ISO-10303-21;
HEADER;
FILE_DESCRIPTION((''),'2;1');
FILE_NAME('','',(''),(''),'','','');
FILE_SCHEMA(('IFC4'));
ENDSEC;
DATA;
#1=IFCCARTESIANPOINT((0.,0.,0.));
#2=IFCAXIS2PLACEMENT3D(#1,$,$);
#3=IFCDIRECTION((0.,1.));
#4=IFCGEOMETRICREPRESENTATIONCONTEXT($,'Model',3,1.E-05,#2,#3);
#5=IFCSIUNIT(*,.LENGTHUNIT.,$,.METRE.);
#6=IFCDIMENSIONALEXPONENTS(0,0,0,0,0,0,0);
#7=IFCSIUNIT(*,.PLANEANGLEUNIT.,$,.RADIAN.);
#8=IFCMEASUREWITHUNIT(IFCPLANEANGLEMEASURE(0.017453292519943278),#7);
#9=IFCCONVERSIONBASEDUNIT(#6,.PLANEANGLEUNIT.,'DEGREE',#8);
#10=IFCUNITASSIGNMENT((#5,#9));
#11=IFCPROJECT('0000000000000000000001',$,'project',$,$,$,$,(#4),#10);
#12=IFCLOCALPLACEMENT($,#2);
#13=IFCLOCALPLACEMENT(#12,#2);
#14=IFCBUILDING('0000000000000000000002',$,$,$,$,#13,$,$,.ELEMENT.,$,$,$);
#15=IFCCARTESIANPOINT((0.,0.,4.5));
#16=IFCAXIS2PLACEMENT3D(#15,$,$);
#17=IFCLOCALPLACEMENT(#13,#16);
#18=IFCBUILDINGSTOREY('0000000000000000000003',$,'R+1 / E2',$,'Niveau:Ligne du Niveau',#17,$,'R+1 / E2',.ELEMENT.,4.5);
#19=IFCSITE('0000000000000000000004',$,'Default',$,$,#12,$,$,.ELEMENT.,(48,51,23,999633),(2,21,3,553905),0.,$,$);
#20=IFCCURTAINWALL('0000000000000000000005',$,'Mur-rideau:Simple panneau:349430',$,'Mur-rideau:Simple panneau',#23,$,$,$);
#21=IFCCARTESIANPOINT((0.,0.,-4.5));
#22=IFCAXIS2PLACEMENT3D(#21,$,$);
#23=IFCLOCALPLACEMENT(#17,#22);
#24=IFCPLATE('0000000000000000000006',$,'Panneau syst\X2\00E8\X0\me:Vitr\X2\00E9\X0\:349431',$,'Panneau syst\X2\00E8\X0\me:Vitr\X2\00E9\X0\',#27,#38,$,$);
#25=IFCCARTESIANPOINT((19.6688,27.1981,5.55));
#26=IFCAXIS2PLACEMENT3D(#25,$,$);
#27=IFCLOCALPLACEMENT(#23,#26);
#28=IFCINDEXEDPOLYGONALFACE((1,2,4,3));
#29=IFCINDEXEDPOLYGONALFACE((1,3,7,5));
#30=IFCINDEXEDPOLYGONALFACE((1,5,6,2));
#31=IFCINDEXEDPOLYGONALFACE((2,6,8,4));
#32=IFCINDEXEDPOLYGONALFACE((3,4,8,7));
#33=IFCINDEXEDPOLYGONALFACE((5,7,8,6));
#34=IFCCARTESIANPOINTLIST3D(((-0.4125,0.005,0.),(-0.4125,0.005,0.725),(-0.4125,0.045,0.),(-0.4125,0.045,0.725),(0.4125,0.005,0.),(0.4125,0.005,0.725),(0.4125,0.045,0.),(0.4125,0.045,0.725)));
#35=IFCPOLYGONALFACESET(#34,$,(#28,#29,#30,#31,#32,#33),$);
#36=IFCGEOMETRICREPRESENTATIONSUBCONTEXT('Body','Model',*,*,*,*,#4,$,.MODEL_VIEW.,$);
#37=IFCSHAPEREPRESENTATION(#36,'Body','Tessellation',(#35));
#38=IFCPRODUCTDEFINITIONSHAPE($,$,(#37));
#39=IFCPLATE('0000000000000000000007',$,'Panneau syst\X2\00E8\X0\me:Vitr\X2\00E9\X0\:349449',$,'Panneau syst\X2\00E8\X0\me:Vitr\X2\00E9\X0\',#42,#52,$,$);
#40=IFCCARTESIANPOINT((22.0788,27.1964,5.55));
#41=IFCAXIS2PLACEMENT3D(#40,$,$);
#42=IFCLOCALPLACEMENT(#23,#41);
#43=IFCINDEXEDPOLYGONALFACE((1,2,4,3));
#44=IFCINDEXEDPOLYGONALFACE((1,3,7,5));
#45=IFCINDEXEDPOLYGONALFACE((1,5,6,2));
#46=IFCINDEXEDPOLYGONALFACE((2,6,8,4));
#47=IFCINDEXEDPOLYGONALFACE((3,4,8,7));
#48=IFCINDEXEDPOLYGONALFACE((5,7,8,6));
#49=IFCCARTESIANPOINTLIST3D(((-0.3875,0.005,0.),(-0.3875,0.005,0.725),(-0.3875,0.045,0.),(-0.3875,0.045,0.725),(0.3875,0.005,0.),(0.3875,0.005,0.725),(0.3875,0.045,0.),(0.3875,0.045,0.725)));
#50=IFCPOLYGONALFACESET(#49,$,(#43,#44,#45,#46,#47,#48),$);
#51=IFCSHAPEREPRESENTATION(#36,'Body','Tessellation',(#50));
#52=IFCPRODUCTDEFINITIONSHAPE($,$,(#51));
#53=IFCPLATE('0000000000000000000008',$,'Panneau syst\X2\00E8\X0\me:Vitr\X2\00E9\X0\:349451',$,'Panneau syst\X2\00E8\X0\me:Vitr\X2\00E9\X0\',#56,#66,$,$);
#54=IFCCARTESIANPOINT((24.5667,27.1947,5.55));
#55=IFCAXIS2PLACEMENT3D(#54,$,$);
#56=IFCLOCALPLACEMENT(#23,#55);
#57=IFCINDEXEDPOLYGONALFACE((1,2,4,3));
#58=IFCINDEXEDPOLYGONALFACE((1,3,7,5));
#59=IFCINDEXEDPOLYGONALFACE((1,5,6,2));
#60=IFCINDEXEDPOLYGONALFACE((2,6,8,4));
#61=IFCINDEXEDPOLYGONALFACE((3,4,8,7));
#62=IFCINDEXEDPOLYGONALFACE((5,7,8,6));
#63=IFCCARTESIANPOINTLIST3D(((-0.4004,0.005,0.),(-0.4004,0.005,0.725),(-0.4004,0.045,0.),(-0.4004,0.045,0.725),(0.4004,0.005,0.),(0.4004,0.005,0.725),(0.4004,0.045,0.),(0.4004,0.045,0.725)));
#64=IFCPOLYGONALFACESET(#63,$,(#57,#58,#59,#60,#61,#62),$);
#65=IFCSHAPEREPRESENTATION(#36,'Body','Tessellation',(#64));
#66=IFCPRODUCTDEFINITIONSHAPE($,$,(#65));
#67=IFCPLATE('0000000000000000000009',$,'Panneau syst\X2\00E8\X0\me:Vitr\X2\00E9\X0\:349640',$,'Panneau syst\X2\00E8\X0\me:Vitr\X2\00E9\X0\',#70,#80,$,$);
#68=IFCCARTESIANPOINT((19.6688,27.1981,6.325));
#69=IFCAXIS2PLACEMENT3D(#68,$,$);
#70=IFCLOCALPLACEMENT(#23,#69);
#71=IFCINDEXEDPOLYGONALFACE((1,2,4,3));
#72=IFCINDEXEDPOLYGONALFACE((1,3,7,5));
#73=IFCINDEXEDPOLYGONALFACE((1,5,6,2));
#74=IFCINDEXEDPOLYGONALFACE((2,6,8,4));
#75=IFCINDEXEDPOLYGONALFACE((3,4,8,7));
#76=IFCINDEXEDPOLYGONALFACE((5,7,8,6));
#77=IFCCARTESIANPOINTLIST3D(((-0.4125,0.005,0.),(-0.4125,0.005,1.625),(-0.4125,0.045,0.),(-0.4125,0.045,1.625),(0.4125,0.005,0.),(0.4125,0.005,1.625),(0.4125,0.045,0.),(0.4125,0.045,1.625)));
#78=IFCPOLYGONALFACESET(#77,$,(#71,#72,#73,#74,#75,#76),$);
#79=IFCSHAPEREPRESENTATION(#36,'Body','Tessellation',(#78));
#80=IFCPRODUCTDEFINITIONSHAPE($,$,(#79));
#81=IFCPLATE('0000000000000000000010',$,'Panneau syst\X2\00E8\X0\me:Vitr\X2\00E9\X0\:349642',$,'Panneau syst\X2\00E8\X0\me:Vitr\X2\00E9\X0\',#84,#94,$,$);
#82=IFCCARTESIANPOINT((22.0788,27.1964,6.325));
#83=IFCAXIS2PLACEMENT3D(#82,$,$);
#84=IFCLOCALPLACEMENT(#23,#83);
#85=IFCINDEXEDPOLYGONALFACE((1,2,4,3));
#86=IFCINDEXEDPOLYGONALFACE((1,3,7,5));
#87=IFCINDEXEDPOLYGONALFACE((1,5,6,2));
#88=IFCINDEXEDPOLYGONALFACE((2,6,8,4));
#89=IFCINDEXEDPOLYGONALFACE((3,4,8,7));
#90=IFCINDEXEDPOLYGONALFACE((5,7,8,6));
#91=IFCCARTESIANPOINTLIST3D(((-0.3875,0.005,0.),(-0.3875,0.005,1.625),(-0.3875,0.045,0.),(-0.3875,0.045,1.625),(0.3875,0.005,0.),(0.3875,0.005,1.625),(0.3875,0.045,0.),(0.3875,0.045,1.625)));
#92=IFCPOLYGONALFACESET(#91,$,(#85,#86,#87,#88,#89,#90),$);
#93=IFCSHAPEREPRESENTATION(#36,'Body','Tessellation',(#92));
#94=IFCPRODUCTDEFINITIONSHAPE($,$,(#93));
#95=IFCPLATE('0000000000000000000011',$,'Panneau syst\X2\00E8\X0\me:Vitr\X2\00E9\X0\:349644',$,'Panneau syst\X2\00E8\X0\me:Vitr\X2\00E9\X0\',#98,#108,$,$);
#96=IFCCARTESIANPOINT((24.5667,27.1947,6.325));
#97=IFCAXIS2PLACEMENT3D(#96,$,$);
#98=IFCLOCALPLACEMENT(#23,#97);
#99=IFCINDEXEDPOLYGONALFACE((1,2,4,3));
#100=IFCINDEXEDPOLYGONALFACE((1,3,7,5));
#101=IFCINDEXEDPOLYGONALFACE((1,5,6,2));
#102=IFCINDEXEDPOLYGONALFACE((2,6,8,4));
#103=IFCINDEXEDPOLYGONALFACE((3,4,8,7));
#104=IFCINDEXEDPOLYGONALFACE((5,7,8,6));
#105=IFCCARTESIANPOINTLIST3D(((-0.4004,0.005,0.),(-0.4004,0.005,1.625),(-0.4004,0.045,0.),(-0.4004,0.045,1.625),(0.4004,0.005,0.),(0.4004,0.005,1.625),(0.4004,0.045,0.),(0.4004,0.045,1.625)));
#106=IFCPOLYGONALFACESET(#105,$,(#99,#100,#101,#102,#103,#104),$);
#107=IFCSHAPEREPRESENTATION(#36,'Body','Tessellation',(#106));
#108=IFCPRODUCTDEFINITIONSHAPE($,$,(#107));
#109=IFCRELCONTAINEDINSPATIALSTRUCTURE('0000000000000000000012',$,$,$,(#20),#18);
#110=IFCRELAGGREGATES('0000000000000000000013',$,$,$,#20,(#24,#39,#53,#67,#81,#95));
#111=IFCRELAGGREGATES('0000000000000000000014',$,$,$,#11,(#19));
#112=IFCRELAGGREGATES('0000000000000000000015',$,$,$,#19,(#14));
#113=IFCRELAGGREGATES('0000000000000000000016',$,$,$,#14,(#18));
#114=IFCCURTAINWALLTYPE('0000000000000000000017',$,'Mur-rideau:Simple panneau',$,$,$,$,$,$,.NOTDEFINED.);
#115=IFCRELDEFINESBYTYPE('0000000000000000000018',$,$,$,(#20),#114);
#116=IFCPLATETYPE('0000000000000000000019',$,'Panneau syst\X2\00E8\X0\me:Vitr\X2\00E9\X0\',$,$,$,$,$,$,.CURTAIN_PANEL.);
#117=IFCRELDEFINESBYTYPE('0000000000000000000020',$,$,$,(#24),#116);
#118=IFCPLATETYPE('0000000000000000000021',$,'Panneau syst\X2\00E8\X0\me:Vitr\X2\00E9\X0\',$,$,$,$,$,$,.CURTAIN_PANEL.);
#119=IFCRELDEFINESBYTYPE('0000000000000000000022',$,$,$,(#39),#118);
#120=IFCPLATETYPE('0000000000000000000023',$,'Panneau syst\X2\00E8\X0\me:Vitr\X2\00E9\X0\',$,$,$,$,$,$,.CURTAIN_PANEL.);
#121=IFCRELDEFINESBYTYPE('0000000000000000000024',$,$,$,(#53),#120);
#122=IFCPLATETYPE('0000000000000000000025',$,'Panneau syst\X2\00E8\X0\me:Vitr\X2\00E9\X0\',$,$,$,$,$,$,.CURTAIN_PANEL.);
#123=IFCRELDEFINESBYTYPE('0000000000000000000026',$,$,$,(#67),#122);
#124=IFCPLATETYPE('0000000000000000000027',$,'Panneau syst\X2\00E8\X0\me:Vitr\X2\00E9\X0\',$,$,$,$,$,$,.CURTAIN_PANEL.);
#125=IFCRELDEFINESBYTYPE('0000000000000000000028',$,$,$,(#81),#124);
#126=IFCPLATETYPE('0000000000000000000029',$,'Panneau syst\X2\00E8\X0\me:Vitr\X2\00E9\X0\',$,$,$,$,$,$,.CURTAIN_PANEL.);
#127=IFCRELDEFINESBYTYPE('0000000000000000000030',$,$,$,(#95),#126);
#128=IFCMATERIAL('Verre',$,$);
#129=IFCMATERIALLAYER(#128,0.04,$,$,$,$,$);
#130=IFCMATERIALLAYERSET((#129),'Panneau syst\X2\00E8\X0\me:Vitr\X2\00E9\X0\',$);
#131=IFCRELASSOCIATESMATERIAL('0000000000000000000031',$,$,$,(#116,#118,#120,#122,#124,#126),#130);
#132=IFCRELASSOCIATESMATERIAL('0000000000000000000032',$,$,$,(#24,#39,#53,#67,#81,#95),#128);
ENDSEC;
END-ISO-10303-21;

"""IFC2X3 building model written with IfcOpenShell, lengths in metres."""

from ifc_helpers import new_model, entity, si_unit, converted_unit, direction, frame, frame_2d, origin, place, context, subcontext, project, spatial, rectangle, extrude, source, transform, mapped, material, layer, layer_set, type_object, type_shapes, element, aggregate, save


model = new_model("IFC2X3")

# Units and contexts
model_context = context("Model", 3, precision=1e-05, world=origin(), true_north=direction((0.0, 1.0)))
body_context = subcontext(model_context, "Body", "Model", "MODEL_VIEW")
ifc_project = project(units=[si_unit("LENGTHUNIT", "METRE"), converted_unit("PLANEANGLEUNIT", "DEGREE", entity("IfcPlaneAngleMeasure", 0.017453292519943278), si_unit("PLANEANGLEUNIT", "RADIAN"), dimensions=[0, 0, 0, 0, 0, 0, 0])], contexts=[model_context])

# Site, building, storey
site_placement = place(None, origin())
site = spatial("IfcSite", under=ifc_project, at=site_placement, Name="Default", CompositionType="ELEMENT", RefLatitude=(48, 51, 23, 999633), RefLongitude=(2, 21, 3, 553905), RefElevation=0.0)
building_placement = place(site_placement, origin())
building = spatial("IfcBuilding", under=site, at=building_placement, CompositionType="ELEMENT")
storey_placement = place(building_placement, frame((0.0, 0.0, 4.5)))
storey = spatial("IfcBuildingStorey", under=building, at=storey_placement, Name="R+1 / E2", ObjectType="Niveau:Ligne du Niveau", LongName="R+1 / E2", CompositionType="ELEMENT", Elevation=4.5)

# Curtain wall
curtain_wall_type = type_object("IfcCurtainWallType", Name="Mur-rideau:Simple panneau", PredefinedType="NOTDEFINED")
curtain_wall_1_placement = place(storey_placement, frame((0.0, 0.0, -4.5)))
curtain_wall_1 = element("IfcCurtainWall", 1, at=curtain_wall_1_placement, inside=storey, type_object=curtain_wall_type, Name="Mur-rideau:Simple panneau:349430", ObjectType="Mur-rideau:Simple panneau")

# Plates
ifc_material_1 = material(Name="Verre")
ifc_layer_1 = layer(ifc_material_1, 0.04)
ifc_layer_set_1 = layer_set([ifc_layer_1], Name="Panneau système:Vitré")
plate_type_1 = type_object("IfcPlateType", Name="Panneau système:Vitré", PredefinedType="CURTAIN_PANEL", material=ifc_layer_set_1)
shared_shape_1 = source(origin(), body_context, "Body", "SweptSolid", [
    extrude(rectangle(XDim=0.04, YDim=0.825, at=frame_2d((0.0, 0.0), x_axis=(1.0, 0.0))), frame((0.0, 0.025, 0.0), z_axis=(0.0, 0.0, 1.0), x_axis=(0.0, 1.0, 0.0)), (0.0, 0.0, 1.0), 0.725),
])
type_shapes(plate_type_1, [shared_shape_1])
plate_1_placement = place(curtain_wall_1_placement, frame((19.6688, 27.1981, 5.55)))
plate_1 = element("IfcPlate", 2, at=plate_1_placement, type_object=plate_type_1, material=ifc_material_1, Name="Panneau système:Vitré:349431", ObjectType="Panneau système:Vitré", context=body_context, shape_type="MappedRepresentation", body=[
    mapped(shared_shape_1, transform((0.0, 0.0, 0.0), scale=1.0)),
])
plate_type_2 = type_object("IfcPlateType", Name="Panneau système:Vitré", PredefinedType="CURTAIN_PANEL", material=ifc_layer_set_1)
shared_shape_2 = source(origin(), body_context, "Body", "SweptSolid", [
    extrude(rectangle(XDim=0.04, YDim=0.775, at=frame_2d((0.0, 0.0), x_axis=(1.0, 0.0))), frame((0.0, 0.025, 0.0), z_axis=(0.0, 0.0, 1.0), x_axis=(0.0, 1.0, 0.0)), (0.0, 0.0, 1.0), 0.725),
])
type_shapes(plate_type_2, [shared_shape_2])
plate_2_placement = place(curtain_wall_1_placement, frame((22.0788, 27.1964, 5.55)))
plate_2 = element("IfcPlate", 3, at=plate_2_placement, type_object=plate_type_2, material=ifc_material_1, Name="Panneau système:Vitré:349449", ObjectType="Panneau système:Vitré", context=body_context, shape_type="MappedRepresentation", body=[
    mapped(shared_shape_2, transform((0.0, 0.0, 0.0), scale=1.0)),
])
plate_type_3 = type_object("IfcPlateType", Name="Panneau système:Vitré", PredefinedType="CURTAIN_PANEL", material=ifc_layer_set_1)
shared_shape_3 = source(origin(), body_context, "Body", "SweptSolid", [
    extrude(rectangle(XDim=0.04, YDim=0.8008, at=frame_2d((0.0, 0.0), x_axis=(1.0, 0.0))), frame((0.0, 0.025, 0.0), z_axis=(0.0, 0.0, 1.0), x_axis=(0.0, 1.0, 0.0)), (0.0, 0.0, 1.0), 0.725),
])
type_shapes(plate_type_3, [shared_shape_3])
plate_3_placement = place(curtain_wall_1_placement, frame((24.5667, 27.1947, 5.55)))
plate_3 = element("IfcPlate", 4, at=plate_3_placement, type_object=plate_type_3, material=ifc_material_1, Name="Panneau système:Vitré:349451", ObjectType="Panneau système:Vitré", context=body_context, shape_type="MappedRepresentation", body=[
    mapped(shared_shape_3, transform((0.0, 0.0, 0.0), scale=1.0)),
])
plate_type_4 = type_object("IfcPlateType", Name="Panneau système:Vitré", PredefinedType="CURTAIN_PANEL", material=ifc_layer_set_1)
shared_shape_4 = source(origin(), body_context, "Body", "SweptSolid", [
    extrude(rectangle(XDim=0.04, YDim=0.825, at=frame_2d((0.0, 0.0), x_axis=(1.0, 0.0))), frame((0.0, 0.025, 0.0), z_axis=(0.0, 0.0, 1.0), x_axis=(0.0, 1.0, 0.0)), (0.0, 0.0, 1.0), 1.625),
])
type_shapes(plate_type_4, [shared_shape_4])
plate_4_placement = place(curtain_wall_1_placement, frame((19.6688, 27.1981, 6.325)))
plate_4 = element("IfcPlate", 5, at=plate_4_placement, type_object=plate_type_4, material=ifc_material_1, Name="Panneau système:Vitré:349640", ObjectType="Panneau système:Vitré", context=body_context, shape_type="MappedRepresentation", body=[
    mapped(shared_shape_4, transform((0.0, 0.0, 0.0), scale=1.0)),
])
plate_type_5 = type_object("IfcPlateType", Name="Panneau système:Vitré", PredefinedType="CURTAIN_PANEL", material=ifc_layer_set_1)
shared_shape_5 = source(origin(), body_context, "Body", "SweptSolid", [
    extrude(rectangle(XDim=0.04, YDim=0.775, at=frame_2d((0.0, 0.0), x_axis=(1.0, 0.0))), frame((0.0, 0.025, 0.0), z_axis=(0.0, 0.0, 1.0), x_axis=(0.0, 1.0, 0.0)), (0.0, 0.0, 1.0), 1.625),
])
type_shapes(plate_type_5, [shared_shape_5])
plate_5_placement = place(curtain_wall_1_placement, frame((22.0788, 27.1964, 6.325)))
plate_5 = element("IfcPlate", 6, at=plate_5_placement, type_object=plate_type_5, material=ifc_material_1, Name="Panneau système:Vitré:349642", ObjectType="Panneau système:Vitré", context=body_context, shape_type="MappedRepresentation", body=[
    mapped(shared_shape_5, transform((0.0, 0.0, 0.0), scale=1.0)),
])
plate_type_6 = type_object("IfcPlateType", Name="Panneau système:Vitré", PredefinedType="CURTAIN_PANEL", material=ifc_layer_set_1)
shared_shape_6 = source(origin(), body_context, "Body", "SweptSolid", [
    extrude(rectangle(XDim=0.04, YDim=0.8008, at=frame_2d((0.0, 0.0), x_axis=(1.0, 0.0))), frame((0.0, 0.025, 0.0), z_axis=(0.0, 0.0, 1.0), x_axis=(0.0, 1.0, 0.0)), (0.0, 0.0, 1.0), 1.625),
])
type_shapes(plate_type_6, [shared_shape_6])
plate_6_placement = place(curtain_wall_1_placement, frame((24.5667, 27.1947, 6.325)))
plate_6 = element("IfcPlate", 7, at=plate_6_placement, type_object=plate_type_6, material=ifc_material_1, Name="Panneau système:Vitré:349644", ObjectType="Panneau système:Vitré", context=body_context, shape_type="MappedRepresentation", body=[
    mapped(shared_shape_6, transform((0.0, 0.0, 0.0), scale=1.0)),
])
aggregate(curtain_wall_1, [plate_1, plate_2, plate_3, plate_4, plate_5, plate_6])

save(model, "model.ifc")
